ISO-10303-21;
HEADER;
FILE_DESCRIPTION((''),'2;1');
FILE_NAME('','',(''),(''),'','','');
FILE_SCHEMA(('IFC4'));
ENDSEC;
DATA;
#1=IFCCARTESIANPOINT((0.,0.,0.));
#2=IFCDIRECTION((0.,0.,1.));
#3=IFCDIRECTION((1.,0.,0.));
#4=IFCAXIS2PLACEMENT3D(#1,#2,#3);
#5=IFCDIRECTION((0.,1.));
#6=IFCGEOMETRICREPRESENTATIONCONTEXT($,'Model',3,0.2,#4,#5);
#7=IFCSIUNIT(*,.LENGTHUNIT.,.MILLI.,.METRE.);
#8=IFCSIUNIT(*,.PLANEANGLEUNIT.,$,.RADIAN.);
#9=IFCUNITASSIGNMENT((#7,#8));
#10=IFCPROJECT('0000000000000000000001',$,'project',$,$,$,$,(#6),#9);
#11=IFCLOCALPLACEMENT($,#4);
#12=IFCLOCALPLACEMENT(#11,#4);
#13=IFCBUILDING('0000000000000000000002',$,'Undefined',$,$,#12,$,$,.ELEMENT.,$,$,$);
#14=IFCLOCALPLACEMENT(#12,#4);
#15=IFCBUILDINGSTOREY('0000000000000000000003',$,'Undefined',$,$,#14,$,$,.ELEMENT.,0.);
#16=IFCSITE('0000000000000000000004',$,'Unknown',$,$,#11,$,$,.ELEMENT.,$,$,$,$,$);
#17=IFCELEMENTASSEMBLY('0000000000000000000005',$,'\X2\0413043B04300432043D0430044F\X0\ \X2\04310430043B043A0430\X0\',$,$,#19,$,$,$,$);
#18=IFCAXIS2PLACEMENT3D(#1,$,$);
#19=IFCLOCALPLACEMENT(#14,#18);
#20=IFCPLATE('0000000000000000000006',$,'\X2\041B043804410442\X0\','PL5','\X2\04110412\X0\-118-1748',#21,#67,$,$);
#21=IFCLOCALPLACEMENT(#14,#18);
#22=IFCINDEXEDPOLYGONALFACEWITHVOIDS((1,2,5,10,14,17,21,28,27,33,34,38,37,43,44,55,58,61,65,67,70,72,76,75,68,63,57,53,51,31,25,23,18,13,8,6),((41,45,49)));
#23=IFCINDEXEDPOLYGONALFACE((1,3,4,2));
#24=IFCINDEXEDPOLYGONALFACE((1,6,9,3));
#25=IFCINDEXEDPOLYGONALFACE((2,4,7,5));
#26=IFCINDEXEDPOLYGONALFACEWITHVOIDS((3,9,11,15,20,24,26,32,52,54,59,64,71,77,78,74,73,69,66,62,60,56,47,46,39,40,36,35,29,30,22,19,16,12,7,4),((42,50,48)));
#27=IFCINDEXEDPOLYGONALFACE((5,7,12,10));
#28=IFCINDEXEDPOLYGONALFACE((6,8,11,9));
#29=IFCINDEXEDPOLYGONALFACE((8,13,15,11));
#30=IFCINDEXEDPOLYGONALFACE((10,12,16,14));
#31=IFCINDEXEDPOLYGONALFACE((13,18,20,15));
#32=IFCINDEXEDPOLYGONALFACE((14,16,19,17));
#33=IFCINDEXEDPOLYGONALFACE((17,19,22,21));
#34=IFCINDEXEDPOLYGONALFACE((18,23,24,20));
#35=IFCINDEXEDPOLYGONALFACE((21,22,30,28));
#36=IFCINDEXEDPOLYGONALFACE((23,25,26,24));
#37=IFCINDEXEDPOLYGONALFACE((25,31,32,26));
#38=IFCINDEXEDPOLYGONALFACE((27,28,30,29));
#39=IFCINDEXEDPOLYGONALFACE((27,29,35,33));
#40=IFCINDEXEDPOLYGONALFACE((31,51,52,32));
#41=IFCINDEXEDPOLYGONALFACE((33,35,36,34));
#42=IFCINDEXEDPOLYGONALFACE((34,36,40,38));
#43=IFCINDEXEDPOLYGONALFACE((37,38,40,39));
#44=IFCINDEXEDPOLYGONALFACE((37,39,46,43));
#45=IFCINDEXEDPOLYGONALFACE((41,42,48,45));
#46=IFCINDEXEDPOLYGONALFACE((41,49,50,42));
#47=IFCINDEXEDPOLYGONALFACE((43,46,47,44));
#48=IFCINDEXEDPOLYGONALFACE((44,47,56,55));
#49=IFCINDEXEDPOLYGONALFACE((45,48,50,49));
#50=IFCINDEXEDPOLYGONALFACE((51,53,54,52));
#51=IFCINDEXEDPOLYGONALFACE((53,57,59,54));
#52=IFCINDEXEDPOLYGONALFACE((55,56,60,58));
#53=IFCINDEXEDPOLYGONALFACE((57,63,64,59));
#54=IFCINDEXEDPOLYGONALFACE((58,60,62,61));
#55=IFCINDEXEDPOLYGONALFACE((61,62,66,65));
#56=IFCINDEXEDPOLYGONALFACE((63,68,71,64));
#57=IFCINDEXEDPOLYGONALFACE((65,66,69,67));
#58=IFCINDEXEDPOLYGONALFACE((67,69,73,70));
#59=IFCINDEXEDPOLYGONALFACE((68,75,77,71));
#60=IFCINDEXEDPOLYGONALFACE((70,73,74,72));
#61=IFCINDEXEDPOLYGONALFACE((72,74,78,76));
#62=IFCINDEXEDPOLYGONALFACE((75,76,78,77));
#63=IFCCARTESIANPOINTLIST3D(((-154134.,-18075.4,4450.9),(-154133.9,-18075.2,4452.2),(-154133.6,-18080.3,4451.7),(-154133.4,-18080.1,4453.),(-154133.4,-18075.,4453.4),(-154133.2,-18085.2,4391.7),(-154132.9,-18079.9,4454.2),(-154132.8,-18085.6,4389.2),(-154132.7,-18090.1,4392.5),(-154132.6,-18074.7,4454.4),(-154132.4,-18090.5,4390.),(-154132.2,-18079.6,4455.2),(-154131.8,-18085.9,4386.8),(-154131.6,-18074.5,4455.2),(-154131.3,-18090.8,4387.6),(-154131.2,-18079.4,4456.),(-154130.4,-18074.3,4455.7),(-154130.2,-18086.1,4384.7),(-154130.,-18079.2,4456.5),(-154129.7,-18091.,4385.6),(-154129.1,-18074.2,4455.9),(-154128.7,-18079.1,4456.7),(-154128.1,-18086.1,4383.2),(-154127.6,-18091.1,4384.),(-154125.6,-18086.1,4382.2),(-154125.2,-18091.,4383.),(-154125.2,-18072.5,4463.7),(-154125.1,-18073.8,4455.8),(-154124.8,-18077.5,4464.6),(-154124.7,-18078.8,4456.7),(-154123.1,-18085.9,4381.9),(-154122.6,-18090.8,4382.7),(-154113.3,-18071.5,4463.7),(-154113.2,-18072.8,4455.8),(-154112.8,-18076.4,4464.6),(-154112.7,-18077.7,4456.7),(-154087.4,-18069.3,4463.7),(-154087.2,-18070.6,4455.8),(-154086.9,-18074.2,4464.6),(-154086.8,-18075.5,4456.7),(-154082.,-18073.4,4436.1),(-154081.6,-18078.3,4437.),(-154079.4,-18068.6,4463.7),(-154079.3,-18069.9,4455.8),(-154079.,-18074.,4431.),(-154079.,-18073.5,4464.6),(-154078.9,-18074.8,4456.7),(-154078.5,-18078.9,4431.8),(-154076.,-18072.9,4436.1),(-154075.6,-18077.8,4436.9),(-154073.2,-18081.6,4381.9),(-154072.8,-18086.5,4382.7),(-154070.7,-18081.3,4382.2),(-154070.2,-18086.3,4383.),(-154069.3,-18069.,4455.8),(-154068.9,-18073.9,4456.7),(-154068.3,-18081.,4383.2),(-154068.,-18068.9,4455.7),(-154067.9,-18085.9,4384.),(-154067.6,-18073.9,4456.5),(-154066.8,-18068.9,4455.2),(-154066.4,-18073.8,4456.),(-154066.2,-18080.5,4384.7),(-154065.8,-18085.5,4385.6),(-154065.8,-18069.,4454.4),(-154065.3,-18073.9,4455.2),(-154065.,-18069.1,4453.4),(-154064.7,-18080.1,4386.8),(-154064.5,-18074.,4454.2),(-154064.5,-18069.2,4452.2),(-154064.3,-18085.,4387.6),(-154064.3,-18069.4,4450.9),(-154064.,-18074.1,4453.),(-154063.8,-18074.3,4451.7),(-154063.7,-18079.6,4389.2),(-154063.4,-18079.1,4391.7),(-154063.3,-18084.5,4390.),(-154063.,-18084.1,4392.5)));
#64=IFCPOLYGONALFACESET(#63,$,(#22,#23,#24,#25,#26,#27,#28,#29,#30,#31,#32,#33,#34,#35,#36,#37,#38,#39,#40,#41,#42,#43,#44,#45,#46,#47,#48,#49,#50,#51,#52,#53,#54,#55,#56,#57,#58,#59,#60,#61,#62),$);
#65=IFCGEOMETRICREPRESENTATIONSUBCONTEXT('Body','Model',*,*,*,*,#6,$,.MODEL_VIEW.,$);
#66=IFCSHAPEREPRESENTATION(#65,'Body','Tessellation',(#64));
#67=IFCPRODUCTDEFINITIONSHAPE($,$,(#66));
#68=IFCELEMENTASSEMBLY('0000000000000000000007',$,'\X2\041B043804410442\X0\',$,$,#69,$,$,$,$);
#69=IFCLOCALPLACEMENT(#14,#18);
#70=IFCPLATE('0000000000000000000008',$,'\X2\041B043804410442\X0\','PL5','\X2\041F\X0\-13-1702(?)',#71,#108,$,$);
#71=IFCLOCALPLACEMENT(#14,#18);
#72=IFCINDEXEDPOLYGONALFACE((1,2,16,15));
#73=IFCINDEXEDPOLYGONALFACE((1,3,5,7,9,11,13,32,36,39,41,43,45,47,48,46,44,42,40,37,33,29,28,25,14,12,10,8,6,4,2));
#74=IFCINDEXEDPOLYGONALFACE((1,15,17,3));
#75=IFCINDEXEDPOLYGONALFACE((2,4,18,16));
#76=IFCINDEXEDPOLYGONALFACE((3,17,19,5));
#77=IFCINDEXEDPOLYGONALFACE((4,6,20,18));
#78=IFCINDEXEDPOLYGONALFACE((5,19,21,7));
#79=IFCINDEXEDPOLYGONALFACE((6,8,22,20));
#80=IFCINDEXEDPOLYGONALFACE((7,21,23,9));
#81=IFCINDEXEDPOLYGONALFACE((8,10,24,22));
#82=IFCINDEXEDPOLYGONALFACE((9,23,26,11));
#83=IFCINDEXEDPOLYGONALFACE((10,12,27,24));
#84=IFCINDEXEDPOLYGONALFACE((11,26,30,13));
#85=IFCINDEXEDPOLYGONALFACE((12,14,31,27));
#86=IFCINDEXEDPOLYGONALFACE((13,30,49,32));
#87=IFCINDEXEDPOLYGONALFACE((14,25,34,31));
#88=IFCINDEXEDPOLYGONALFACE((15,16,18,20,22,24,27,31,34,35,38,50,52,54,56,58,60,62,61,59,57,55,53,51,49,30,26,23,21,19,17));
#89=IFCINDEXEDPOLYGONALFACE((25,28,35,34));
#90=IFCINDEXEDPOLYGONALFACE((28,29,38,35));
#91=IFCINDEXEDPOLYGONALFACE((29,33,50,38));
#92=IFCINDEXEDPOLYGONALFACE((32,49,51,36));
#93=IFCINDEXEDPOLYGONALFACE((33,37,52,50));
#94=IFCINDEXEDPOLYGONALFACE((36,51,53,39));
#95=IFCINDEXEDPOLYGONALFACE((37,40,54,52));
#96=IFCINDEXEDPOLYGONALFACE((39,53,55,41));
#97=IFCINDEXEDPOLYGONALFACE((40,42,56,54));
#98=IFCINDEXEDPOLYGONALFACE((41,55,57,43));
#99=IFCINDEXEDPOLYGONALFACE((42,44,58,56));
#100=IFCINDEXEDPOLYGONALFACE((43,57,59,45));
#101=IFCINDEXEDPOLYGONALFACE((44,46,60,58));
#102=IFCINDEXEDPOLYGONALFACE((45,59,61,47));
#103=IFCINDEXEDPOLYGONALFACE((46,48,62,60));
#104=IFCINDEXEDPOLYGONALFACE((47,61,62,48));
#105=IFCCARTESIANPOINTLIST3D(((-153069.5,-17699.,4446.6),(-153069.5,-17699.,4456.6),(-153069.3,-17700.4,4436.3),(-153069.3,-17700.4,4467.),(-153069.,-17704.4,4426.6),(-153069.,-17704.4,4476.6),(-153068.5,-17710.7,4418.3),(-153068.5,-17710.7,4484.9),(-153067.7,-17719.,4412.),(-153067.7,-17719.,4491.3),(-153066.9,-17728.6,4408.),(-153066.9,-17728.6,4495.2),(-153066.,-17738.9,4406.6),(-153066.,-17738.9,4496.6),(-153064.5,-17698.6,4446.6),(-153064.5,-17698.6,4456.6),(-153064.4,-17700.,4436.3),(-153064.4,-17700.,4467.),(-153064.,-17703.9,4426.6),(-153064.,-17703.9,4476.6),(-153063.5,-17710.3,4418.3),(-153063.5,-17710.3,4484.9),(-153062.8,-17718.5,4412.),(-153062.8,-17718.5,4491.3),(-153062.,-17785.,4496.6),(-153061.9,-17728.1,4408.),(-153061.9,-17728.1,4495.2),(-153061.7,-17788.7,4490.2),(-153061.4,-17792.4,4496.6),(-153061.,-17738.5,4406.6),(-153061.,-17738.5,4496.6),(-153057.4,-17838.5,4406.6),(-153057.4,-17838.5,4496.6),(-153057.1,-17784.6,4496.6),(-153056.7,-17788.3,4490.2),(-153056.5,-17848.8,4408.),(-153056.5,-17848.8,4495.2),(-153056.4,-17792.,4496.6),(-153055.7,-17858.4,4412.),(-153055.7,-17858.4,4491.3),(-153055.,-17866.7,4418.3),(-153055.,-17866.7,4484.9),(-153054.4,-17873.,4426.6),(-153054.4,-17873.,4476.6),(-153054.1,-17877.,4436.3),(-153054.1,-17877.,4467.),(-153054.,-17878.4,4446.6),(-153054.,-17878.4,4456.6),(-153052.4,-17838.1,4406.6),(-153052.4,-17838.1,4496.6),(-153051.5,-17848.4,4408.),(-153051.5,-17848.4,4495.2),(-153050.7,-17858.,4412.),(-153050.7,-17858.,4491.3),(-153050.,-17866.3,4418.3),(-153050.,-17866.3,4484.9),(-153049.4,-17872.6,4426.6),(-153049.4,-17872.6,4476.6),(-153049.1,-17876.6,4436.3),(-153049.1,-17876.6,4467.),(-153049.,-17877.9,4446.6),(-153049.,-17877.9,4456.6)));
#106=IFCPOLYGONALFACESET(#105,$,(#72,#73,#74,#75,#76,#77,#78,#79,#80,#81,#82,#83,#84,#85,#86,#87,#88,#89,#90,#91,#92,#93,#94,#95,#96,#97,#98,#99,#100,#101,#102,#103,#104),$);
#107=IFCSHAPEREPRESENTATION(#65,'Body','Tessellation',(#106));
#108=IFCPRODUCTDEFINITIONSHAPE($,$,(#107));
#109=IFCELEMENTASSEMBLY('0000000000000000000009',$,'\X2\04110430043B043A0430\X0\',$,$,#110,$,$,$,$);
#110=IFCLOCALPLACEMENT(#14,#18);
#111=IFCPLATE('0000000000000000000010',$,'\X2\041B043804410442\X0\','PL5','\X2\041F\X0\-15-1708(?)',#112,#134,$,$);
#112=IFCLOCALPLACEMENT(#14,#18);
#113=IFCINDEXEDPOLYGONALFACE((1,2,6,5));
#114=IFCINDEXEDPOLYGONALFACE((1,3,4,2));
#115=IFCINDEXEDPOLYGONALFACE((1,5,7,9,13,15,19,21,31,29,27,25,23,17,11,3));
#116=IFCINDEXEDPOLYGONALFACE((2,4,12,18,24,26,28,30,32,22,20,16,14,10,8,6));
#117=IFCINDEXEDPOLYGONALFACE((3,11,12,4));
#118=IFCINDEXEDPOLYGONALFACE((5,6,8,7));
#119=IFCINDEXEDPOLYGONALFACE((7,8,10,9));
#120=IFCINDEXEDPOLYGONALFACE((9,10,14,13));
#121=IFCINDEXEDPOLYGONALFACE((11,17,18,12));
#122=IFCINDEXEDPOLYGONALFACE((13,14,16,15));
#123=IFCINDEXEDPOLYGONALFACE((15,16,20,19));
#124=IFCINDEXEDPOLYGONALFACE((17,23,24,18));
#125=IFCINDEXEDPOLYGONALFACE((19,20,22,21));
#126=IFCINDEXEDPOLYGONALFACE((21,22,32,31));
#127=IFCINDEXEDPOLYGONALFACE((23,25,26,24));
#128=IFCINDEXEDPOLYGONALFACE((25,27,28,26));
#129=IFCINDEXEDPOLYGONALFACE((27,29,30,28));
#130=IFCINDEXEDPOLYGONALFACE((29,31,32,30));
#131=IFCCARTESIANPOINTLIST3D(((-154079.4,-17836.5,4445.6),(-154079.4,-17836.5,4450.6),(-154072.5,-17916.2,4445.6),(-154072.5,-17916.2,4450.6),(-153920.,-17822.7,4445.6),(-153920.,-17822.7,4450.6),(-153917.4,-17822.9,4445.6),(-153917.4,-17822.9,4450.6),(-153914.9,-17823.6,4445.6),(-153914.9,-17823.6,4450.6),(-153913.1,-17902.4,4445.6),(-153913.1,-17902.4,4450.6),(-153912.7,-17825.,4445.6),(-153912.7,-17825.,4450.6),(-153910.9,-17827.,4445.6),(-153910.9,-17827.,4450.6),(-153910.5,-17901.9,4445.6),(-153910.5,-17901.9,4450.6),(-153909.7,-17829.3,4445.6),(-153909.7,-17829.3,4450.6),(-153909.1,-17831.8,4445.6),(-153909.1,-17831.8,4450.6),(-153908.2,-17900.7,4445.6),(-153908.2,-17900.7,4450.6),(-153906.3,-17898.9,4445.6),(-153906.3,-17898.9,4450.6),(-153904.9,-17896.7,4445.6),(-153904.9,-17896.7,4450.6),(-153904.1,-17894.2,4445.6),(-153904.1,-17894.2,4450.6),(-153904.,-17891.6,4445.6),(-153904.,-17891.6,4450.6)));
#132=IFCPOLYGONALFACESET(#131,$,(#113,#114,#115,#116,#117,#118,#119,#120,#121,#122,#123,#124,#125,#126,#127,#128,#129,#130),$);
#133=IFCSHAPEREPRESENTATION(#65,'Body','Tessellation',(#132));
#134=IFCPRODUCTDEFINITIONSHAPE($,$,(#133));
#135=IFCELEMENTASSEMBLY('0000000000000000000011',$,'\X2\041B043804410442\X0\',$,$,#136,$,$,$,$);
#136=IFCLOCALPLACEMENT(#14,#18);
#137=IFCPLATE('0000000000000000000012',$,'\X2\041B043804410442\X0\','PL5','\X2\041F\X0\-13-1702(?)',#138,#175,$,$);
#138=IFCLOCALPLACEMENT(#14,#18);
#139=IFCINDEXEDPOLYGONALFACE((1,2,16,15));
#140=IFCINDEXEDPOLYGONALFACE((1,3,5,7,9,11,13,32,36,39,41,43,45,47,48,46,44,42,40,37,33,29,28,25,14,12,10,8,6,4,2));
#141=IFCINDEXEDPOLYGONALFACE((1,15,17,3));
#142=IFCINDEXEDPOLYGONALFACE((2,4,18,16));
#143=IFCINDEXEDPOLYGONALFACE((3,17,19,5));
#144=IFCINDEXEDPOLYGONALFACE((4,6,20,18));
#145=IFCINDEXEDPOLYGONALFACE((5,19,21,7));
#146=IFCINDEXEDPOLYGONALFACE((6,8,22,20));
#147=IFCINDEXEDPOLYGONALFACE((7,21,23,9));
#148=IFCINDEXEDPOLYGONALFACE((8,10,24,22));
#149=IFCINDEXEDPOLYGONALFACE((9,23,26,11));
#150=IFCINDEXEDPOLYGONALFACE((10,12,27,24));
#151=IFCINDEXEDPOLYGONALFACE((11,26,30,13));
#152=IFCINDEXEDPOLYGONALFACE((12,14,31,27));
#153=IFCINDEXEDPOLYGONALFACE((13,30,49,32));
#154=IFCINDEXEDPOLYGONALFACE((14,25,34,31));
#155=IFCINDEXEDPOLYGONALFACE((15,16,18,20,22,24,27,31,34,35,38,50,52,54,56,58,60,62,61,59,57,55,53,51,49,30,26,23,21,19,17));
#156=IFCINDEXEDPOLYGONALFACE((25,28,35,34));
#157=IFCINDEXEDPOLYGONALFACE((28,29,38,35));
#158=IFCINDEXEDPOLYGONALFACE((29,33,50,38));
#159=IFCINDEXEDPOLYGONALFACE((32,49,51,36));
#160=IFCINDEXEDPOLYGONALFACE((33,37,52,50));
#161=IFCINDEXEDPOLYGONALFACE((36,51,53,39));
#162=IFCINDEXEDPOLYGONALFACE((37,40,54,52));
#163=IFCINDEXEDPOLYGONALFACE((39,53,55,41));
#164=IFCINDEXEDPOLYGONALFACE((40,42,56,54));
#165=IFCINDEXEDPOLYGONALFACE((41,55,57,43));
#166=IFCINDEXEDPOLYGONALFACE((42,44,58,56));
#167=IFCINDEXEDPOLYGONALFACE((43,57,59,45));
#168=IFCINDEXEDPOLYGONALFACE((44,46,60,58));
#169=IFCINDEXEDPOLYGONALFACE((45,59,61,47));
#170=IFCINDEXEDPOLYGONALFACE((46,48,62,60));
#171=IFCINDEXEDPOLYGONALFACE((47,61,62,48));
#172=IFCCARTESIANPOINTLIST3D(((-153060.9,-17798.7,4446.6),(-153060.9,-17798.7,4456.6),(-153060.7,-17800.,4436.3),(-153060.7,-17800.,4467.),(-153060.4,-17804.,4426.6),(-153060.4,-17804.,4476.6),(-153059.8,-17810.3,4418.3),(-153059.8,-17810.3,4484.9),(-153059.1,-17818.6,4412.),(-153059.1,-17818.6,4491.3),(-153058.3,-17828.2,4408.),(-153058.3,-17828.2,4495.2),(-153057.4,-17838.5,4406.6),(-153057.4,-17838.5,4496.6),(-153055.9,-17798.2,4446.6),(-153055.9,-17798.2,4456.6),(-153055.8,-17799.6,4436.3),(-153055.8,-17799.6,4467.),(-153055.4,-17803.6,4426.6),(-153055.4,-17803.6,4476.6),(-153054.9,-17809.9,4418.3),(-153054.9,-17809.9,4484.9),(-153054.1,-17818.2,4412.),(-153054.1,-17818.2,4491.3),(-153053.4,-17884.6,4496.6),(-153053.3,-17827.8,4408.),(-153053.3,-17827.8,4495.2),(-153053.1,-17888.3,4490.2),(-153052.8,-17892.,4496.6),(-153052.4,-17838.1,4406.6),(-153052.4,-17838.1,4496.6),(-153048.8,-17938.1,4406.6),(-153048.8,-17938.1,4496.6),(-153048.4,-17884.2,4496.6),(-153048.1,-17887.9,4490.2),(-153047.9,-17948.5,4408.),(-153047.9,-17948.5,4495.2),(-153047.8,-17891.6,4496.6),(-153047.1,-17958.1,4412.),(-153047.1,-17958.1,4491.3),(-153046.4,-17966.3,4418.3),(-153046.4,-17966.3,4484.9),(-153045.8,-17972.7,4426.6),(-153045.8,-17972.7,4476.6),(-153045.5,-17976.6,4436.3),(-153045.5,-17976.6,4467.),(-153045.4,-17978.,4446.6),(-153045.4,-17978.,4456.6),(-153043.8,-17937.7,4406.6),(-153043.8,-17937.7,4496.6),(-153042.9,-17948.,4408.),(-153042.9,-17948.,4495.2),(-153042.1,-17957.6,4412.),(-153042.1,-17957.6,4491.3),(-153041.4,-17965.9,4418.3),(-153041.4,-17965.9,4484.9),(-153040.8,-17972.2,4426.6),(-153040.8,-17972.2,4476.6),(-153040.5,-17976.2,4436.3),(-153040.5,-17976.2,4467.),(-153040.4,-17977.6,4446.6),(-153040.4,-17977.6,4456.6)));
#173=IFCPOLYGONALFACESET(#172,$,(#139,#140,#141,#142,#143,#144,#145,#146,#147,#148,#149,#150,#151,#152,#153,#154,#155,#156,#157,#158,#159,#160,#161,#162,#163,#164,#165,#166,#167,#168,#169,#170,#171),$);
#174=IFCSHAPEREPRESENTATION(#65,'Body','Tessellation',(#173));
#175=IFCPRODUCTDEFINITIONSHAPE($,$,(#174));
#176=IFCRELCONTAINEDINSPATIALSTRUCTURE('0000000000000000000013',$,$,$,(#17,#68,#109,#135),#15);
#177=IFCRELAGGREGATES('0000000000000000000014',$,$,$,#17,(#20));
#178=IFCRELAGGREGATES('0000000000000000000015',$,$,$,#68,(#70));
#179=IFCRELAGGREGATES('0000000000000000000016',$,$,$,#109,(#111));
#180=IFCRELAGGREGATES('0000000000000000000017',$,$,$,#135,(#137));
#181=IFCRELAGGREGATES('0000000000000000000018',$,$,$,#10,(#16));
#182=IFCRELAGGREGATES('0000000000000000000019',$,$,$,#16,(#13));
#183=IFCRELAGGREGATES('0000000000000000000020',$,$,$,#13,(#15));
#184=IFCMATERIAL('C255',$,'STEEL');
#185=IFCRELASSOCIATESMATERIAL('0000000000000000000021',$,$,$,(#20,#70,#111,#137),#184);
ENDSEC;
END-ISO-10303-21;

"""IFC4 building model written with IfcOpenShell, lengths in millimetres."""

from ifc_helpers import new_model, si_unit, direction, frame, origin_with_axes, place, context, subcontext, project, spatial, line, arc, indexed_curve, outline, extrude, material, element, aggregate, save


model = new_model("IFC4")

# Units and contexts
model_context = context("Model", 3, precision=0.2, world=origin_with_axes(), true_north=direction((0.0, 1.0)))
body_context = subcontext(model_context, "Body", "Model", "MODEL_VIEW")
ifc_project = project(units=[si_unit("LENGTHUNIT", "METRE", prefix="MILLI"), si_unit("PLANEANGLEUNIT", "RADIAN")], contexts=[model_context])

# Site, building, storey
site_placement = place(None, origin_with_axes())
site = spatial("IfcSite", under=ifc_project, at=site_placement, Name="Unknown", CompositionType="ELEMENT")
building_placement = place(site_placement, origin_with_axes())
building = spatial("IfcBuilding", under=site, at=building_placement, Name="Undefined", CompositionType="ELEMENT")
storey_placement = place(building_placement, origin_with_axes())
storey = spatial("IfcBuildingStorey", under=building, at=storey_placement, Name="Undefined", CompositionType="ELEMENT", Elevation=0.0)

# Shared definitions
ifc_material_1 = material(Name="C255", Category="STEEL")

# Element assemblies, plates, voiding features
assembly_1_placement = place(storey_placement, frame((-154120.8, -17880.2, 4484.9), z_axis=(-0.996285, -0.086114, 0.000024), x_axis=(0.084961, -0.982981, 0.162881)))
assembly_1 = element("IfcElementAssembly", 1, at=assembly_1_placement, inside=storey, Name="Главная балка")
plate_1_placement = place(assembly_1_placement, frame((187.7, -135.0, -40.0), z_axis=(-1.0, -0.000054, 0.0), x_axis=(0.0, 0.000054, 1.0)))
plate_1 = element("IfcPlate", 2, at=plate_1_placement, material=ifc_material_1, Name="Лист", Description="PL5", ObjectType="БВ-118-1748", context=body_context, shape_type="SolidModel", body=[
    extrude(outline(indexed_curve([(0.0, 10.0), (2.9, 2.9), (10.0, 0.0), (60.0, 0.0), (67.1, 2.9), (70.0, 10.0), (70.0, 70.0), (68.5, 73.5), (65.0, 75.0), (61.0, 75.0), (61.0, 83.0), (49.0, 83.0), (49.0, 75.0), (23.0, 75.0), (23.0, 83.0), (15.0, 83.0), (15.0, 75.0), (5.0, 75.0), (1.5, 73.5), (0.0, 70.0)], segments=[arc(1, 2, 3), line(3, 4), arc(4, 5, 6), line(6, 7), arc(7, 8, 9), line(9, 10, 11, 12, 13, 14, 15, 16, 17, 18), arc(18, 19, 20), line(20, 1)])), frame((0.0, 0.0, 2.5), z_axis=(0.0, 0.0, 1.0), x_axis=(1.0, 0.0, 0.0)), (0.0, 0.0, -1.0), 5.0),
])
voiding_feature_1_placement = place(plate_1_placement, frame((15.0, 55.0, 10.0), z_axis=(0.007997, -0.999968, -0.000026), x_axis=(0.0, 0.000026, -1.0)))
element("IfcVoidingFeature", 3, at=voiding_feature_1_placement, cuts=plate_1, Name="Балка", ObjectType="(?)", PredefinedType="HOLE", context=body_context, shape_type="SolidModel", body=[
    extrude(outline(indexed_curve([(0.0, -3.0), (5.2, 0.0), (0.0, 3.0)], segments=[line(1, 2, 3, 1)])), frame((0.0, 0.0, 0.0), z_axis=(-1.0, 0.0, 0.0), x_axis=(0.0, 0.0, 1.0)), (0.0, 0.0, -1.0), 20.0),
])
aggregate(assembly_1, [plate_1])
assembly_2_placement = place(storey_placement, frame((-153051.5, -17878.2, 4406.6), z_axis=(-0.996285, -0.086114, 0.0), x_axis=(0.0, 0.0, 1.0)))
assembly_2 = element("IfcElementAssembly", 4, at=assembly_2_placement, inside=storey, Name="Лист")
plate_2_placement = place(assembly_2_placement, origin_with_axes())
plate_2 = element("IfcPlate", 5, at=plate_2_placement, material=ifc_material_1, Name="Лист", Description="PL5", ObjectType="П-13-1702(?)", context=body_context, shape_type="SolidModel", body=[
    extrude(outline(indexed_curve([(0.0, 40.0), (11.7, 11.7), (40.0, 0.0), (50.0, 0.0), (78.3, 11.7), (90.0, 40.0), (90.0, 140.0), (78.3, 168.3), (50.0, 180.0), (40.0, 180.0), (11.7, 168.3), (0.0, 140.0)], segments=[arc(1, 2, 3), line(3, 4), arc(4, 5, 6), line(6, 7), arc(7, 8, 9), line(9, 10), arc(10, 11, 12), line(12, 1)])), frame((0.0, 0.0, 2.5), z_axis=(0.0, 0.0, 1.0), x_axis=(1.0, 0.0, 0.0)), (0.0, 0.0, -1.0), 5.0),
])
voiding_feature_2_placement = place(plate_2_placement, frame((90.5, 90.0, -3.5), z_axis=(-1.0, -0.000054, 0.0), x_axis=(0.0, 0.0, 1.0)))
element("IfcVoidingFeature", 6, at=voiding_feature_2_placement, cuts=plate_2, Name="Связь вертикальная", ObjectType="(?)", PredefinedType="HOLE", context=body_context, shape_type="SolidModel", body=[
    extrude(outline(indexed_curve([(0.0, -4.0), (6.9, 0.0), (0.0, 4.0)], segments=[line(1, 2, 3, 1)])), frame((0.0, 0.0, 0.0), z_axis=(-1.0, 0.0, 0.0), x_axis=(0.0, 0.0, 1.0)), (0.0, 0.0, -1.0), 7.0),
])
aggregate(assembly_2, [plate_2])

# Element assembly, plate
assembly_3_placement = place(storey_placement, frame((-154078.4, -17876.6, 4581.6), z_axis=(0.996285, 0.086114, 0.0), x_axis=(0.0, 0.0, -1.0)))
assembly_3 = element("IfcElementAssembly", 7, at=assembly_3_placement, inside=storey, Name="Балка")
plate_3_placement = place(assembly_3_placement, frame((133.5, 40.0, 2.5), z_axis=(-1.0, 0.0, 0.0), x_axis=(0.0, -1.0, 0.0)))
plate_3 = element("IfcPlate", 8, at=plate_3_placement, material=ifc_material_1, Name="Лист", Description="PL5", ObjectType="П-15-1708(?)", context=body_context, shape_type="SolidModel", body=[
    extrude(outline(indexed_curve([(0.0, 0.0), (80.0, 0.0), (80.0, 160.0), (77.1, 167.1), (70.0, 170.0), (10.0, 170.0), (2.9, 167.1), (0.0, 160.0)], segments=[line(1, 2, 3), arc(3, 4, 5), line(5, 6), arc(6, 7, 8), line(8, 1)])), frame((0.0, 0.0, 2.5), z_axis=(0.0, 0.0, 1.0), x_axis=(1.0, 0.0, 0.0)), (0.0, 0.0, -1.0), 5.0),
])
aggregate(assembly_3, [plate_3])

# Element assembly, plate, voiding feature
assembly_4_placement = place(storey_placement, frame((-153042.9, -17977.8, 4406.6), z_axis=(-0.996285, -0.086114, 0.0), x_axis=(0.0, 0.0, 1.0)))
assembly_4 = element("IfcElementAssembly", 9, at=assembly_4_placement, inside=storey, Name="Лист")
plate_4_placement = place(assembly_4_placement, origin_with_axes())
plate_4 = element("IfcPlate", 10, at=plate_4_placement, material=ifc_material_1, Name="Лист", Description="PL5", ObjectType="П-13-1702(?)", context=body_context, shape_type="SolidModel", body=[
    extrude(outline(indexed_curve([(0.0, 40.0), (11.7, 11.7), (40.0, 0.0), (50.0, 0.0), (78.3, 11.7), (90.0, 40.0), (90.0, 140.0), (78.3, 168.3), (50.0, 180.0), (40.0, 180.0), (11.7, 168.3), (0.0, 140.0)], segments=[arc(1, 2, 3), line(3, 4), arc(4, 5, 6), line(6, 7), arc(7, 8, 9), line(9, 10), arc(10, 11, 12), line(12, 1)])), frame((0.0, 0.0, 2.5), z_axis=(0.0, 0.0, 1.0), x_axis=(1.0, 0.0, 0.0)), (0.0, 0.0, -1.0), 5.0),
])
voiding_feature_3_placement = place(plate_4_placement, frame((90.5, 90.0, -3.5), z_axis=(-1.0, -0.000054, 0.0), x_axis=(0.0, 0.0, 1.0)))
element("IfcVoidingFeature", 11, at=voiding_feature_3_placement, cuts=plate_4, Name="Связь вертикальная", ObjectType="(?)", PredefinedType="HOLE", context=body_context, shape_type="SolidModel", body=[
    extrude(outline(indexed_curve([(0.0, -4.0), (6.9, 0.0), (0.0, 4.0)], segments=[line(1, 2, 3, 1)])), frame((0.0, 0.0, 0.0), z_axis=(-1.0, 0.0, 0.0), x_axis=(0.0, 0.0, 1.0)), (0.0, 0.0, -1.0), 7.0),
])
aggregate(assembly_4, [plate_4])

save(model, "model.ifc")
